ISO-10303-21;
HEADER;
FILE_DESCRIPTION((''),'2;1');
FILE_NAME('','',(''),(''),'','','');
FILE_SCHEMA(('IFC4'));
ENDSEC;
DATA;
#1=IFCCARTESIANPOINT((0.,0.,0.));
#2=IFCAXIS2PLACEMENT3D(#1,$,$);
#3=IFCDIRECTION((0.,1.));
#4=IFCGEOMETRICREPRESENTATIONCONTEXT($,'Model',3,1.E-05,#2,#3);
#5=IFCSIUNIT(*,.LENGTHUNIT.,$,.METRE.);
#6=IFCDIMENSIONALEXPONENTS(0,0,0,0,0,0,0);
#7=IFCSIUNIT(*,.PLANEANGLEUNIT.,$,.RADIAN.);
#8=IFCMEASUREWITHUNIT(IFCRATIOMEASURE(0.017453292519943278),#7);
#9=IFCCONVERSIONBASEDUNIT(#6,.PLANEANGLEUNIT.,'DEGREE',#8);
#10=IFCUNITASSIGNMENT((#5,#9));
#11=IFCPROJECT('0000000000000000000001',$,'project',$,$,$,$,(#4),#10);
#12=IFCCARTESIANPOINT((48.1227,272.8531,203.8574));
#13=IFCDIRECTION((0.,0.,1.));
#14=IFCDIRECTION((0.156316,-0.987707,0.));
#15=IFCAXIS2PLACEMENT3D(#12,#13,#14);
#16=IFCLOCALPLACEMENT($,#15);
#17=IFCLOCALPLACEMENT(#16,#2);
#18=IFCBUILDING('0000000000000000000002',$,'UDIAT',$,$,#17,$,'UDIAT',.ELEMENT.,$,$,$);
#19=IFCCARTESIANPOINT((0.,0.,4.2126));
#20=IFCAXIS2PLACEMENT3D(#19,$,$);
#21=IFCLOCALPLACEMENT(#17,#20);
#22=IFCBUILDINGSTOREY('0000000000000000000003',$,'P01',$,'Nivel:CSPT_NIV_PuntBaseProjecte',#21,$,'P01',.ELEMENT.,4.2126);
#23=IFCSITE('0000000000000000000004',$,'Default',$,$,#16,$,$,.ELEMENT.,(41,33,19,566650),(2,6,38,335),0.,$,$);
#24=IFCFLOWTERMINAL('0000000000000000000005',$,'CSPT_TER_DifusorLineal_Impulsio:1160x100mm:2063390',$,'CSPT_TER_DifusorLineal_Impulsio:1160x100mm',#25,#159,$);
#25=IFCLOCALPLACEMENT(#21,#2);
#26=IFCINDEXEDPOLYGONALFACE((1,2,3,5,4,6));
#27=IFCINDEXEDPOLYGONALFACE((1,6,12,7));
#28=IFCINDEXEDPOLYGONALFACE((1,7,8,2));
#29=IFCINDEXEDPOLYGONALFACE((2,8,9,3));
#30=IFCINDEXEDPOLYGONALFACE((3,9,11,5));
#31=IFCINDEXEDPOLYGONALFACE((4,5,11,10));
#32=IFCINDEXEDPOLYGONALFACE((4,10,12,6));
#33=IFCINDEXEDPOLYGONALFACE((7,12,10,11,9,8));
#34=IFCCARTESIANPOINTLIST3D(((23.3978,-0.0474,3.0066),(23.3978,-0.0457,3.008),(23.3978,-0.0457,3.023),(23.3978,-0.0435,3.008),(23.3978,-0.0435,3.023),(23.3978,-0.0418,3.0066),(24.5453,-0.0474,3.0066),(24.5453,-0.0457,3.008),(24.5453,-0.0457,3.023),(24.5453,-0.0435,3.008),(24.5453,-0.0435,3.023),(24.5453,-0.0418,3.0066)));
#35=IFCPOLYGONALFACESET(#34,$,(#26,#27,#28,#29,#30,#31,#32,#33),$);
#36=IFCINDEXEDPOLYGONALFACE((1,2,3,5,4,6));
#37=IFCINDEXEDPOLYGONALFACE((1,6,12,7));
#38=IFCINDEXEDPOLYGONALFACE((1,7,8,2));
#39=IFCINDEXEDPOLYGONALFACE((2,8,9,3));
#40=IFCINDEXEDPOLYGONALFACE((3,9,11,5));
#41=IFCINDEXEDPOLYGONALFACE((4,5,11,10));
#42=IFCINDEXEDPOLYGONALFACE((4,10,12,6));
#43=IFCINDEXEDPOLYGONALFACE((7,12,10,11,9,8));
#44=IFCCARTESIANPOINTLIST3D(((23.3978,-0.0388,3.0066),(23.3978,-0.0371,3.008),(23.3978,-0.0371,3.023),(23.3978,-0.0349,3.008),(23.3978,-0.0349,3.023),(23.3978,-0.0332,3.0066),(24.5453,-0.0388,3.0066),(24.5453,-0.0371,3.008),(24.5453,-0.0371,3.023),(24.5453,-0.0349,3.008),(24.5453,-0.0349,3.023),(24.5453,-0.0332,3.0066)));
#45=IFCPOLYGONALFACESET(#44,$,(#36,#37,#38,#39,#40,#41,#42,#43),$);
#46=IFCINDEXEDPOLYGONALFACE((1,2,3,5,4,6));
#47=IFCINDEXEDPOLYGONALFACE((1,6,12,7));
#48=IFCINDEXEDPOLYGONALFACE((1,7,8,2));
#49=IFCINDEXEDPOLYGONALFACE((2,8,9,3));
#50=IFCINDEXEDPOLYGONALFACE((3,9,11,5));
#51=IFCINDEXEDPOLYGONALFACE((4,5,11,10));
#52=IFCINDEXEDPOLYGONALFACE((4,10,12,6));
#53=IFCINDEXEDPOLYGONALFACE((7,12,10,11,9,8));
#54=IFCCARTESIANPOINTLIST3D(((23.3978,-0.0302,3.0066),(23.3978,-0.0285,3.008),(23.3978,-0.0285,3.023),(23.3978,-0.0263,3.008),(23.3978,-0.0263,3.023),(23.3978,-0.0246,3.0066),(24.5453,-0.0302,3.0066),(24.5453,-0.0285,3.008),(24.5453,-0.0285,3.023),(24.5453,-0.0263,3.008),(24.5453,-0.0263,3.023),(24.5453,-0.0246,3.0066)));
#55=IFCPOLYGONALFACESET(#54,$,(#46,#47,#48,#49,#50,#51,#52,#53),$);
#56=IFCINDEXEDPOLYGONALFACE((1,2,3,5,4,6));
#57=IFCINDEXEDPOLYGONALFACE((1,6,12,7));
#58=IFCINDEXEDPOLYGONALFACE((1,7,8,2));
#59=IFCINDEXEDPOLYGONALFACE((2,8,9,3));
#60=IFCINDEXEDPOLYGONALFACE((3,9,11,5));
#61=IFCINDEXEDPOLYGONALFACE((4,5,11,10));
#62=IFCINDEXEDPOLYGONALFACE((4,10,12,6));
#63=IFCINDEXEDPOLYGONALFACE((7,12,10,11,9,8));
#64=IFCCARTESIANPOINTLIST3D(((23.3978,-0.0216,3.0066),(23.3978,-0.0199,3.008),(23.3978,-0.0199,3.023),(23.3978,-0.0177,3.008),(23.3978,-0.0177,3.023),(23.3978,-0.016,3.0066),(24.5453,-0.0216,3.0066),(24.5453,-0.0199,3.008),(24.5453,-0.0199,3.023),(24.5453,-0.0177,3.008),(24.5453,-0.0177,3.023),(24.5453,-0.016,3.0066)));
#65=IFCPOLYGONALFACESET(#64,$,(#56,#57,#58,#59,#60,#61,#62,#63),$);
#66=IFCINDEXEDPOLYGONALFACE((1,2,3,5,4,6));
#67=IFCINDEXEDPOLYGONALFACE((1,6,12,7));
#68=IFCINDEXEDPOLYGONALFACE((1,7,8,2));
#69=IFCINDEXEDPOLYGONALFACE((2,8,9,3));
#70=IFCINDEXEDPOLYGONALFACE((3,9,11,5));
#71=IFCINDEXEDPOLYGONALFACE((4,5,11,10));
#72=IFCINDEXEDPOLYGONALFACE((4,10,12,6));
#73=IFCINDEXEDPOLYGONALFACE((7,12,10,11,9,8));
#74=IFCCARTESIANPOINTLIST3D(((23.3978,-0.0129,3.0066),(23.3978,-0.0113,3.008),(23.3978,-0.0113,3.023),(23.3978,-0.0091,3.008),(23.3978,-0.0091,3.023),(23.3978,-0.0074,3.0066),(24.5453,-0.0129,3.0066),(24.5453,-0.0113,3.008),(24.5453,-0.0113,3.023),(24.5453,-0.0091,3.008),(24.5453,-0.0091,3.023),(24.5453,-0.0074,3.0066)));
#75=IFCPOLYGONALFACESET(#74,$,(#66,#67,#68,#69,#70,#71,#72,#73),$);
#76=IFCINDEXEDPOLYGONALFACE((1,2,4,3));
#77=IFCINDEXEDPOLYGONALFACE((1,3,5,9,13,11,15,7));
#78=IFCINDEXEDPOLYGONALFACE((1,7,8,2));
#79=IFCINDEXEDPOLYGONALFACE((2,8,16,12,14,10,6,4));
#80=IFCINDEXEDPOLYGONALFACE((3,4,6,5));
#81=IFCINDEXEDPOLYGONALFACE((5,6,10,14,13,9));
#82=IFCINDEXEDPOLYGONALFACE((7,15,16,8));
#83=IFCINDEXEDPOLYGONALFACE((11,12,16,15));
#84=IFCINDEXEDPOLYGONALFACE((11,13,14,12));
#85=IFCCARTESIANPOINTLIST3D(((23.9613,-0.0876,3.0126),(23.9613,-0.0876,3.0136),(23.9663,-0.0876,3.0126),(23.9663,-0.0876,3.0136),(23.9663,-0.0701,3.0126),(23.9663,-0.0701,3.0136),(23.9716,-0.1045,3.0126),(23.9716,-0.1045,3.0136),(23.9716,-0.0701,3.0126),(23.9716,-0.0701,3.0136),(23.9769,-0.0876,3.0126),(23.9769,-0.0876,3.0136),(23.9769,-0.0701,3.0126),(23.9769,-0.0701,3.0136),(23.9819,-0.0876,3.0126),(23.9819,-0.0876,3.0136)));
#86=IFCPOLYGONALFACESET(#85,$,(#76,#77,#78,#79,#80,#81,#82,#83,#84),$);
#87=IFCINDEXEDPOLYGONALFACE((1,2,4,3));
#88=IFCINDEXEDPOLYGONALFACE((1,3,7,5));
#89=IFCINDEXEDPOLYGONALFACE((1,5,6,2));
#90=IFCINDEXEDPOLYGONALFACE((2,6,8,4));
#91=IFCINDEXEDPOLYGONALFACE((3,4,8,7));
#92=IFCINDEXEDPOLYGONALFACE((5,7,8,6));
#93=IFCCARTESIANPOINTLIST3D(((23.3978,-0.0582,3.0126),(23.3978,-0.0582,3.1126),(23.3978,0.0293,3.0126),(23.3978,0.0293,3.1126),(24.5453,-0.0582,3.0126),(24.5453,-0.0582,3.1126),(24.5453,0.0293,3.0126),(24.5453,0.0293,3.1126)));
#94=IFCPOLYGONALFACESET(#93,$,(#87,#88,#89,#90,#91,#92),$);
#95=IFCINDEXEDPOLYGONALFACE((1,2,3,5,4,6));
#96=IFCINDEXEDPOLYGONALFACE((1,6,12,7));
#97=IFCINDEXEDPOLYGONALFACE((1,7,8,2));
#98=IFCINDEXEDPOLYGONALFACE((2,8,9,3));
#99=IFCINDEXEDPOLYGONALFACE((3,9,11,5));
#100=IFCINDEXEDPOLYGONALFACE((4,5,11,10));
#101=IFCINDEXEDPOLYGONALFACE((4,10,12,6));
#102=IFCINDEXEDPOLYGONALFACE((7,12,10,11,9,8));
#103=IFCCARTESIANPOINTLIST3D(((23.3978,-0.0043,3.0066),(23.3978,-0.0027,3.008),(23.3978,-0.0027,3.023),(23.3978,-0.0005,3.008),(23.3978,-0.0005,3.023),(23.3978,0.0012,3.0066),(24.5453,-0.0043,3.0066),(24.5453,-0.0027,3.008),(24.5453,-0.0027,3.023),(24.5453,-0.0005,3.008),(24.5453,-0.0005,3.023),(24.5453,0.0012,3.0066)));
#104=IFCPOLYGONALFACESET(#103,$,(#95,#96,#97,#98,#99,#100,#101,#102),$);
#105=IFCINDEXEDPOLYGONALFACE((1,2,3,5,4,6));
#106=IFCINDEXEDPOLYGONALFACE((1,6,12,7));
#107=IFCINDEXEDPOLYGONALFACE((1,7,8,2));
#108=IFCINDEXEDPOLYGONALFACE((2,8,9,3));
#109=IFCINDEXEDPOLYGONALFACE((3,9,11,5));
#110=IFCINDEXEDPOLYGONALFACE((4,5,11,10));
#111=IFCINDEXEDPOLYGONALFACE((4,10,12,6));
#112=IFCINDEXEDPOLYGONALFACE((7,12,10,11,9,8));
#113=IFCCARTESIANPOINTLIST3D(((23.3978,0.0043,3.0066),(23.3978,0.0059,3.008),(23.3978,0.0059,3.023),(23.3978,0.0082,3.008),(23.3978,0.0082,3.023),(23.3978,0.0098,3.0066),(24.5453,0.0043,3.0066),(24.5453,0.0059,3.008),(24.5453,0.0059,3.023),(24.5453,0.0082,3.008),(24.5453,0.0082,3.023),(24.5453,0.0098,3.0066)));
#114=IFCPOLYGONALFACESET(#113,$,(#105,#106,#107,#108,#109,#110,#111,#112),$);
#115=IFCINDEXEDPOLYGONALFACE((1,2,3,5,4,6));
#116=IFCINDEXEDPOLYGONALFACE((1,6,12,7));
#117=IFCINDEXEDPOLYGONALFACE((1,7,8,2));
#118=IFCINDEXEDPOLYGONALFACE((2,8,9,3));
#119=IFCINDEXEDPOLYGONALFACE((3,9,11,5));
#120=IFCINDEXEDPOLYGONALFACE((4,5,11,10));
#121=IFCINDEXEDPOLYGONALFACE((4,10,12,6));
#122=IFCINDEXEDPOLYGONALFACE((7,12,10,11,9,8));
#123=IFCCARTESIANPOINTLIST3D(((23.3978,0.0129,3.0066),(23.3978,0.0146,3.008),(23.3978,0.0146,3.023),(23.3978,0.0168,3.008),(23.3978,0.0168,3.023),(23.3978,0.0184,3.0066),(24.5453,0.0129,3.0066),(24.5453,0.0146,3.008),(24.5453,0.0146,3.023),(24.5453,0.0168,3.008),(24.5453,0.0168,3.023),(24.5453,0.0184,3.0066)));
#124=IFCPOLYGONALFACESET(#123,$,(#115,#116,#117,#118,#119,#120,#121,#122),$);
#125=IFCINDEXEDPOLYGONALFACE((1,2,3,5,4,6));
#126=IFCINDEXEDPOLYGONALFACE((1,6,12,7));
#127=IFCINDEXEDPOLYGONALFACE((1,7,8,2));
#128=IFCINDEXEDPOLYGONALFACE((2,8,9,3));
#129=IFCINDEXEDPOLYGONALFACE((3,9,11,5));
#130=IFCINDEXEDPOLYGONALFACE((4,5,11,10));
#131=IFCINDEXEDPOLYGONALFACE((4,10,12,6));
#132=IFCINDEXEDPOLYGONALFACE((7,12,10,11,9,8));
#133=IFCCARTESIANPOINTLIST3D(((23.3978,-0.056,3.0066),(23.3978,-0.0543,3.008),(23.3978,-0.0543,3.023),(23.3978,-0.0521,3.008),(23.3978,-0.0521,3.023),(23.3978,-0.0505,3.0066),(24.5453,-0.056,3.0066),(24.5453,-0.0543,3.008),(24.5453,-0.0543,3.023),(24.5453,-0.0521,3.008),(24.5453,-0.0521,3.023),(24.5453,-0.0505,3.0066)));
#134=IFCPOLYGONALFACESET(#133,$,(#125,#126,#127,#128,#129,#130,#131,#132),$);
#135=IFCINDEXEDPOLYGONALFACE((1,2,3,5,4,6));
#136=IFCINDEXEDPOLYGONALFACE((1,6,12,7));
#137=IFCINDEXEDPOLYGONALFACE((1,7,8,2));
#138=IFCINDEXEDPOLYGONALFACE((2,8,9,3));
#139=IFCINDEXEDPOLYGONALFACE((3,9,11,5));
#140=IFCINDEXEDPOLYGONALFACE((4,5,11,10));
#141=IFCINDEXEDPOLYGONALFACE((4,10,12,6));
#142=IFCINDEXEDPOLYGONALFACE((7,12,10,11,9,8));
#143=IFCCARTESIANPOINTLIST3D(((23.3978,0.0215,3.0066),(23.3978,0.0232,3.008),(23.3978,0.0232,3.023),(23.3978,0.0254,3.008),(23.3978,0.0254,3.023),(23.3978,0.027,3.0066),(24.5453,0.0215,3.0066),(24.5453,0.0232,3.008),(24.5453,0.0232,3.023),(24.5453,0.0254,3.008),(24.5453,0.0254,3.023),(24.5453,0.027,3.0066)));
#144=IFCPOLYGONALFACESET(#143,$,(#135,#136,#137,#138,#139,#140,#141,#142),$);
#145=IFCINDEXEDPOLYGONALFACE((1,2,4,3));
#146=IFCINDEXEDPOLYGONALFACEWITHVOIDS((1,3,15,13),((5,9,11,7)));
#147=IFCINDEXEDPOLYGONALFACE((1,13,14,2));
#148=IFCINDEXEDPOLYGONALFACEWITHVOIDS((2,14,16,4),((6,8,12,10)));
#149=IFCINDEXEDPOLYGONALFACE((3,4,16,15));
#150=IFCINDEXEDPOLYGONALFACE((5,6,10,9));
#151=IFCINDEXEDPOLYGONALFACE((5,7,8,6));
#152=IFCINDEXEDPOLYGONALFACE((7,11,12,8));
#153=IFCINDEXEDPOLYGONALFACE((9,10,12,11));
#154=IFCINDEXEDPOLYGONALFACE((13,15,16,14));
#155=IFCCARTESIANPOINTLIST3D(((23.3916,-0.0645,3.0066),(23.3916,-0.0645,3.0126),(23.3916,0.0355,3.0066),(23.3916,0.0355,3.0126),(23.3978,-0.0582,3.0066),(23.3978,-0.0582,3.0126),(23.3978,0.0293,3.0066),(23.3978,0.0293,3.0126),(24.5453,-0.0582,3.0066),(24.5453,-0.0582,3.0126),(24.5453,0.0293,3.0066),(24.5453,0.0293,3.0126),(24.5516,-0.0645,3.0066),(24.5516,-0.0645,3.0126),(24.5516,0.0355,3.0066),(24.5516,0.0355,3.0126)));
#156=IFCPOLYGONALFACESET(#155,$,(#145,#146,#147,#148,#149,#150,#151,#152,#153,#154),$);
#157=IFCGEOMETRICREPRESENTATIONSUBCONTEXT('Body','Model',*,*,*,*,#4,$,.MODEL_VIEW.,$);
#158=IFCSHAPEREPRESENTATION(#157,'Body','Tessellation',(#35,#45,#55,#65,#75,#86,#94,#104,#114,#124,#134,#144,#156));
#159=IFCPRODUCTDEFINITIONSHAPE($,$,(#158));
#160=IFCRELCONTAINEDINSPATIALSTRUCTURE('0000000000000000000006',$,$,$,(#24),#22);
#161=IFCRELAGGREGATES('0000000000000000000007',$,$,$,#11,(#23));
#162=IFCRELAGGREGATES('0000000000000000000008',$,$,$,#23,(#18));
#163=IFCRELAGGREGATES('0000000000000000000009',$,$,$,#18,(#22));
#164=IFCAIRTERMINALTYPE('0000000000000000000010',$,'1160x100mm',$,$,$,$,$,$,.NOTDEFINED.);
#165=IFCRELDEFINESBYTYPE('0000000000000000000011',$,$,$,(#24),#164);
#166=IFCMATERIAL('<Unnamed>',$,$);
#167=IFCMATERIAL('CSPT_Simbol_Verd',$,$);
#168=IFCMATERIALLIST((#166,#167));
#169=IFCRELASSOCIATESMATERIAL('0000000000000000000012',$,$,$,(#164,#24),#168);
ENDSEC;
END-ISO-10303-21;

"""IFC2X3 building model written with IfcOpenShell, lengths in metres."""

from ifc_helpers import new_model, entity, si_unit, converted_unit, direction, frame, origin, origin_2d_with_axis, place, context, subcontext, project, spatial, polyline, rectangle, outline, extrude, source, transform, mapped, material, material_list, type_object, type_shapes, element, save


model = new_model("IFC2X3")

# Units and contexts
model_context = context("Model", 3, precision=1e-05, world=origin(), true_north=direction((0.0, 1.0)))
body_context = subcontext(model_context, "Body", "Model", "MODEL_VIEW")
ifc_project = project(units=[si_unit("LENGTHUNIT", "METRE"), converted_unit("PLANEANGLEUNIT", "DEGREE", entity("IfcRatioMeasure", 0.017453292519943278), si_unit("PLANEANGLEUNIT", "RADIAN"), dimensions=[0, 0, 0, 0, 0, 0, 0])], contexts=[model_context])

# Site, building, storey
site_placement = place(None, frame((48.1227, 272.8531, 203.8574), z_axis=(0.0, 0.0, 1.0), x_axis=(0.156316, -0.987707, 0.0)))
site = spatial("IfcSite", under=ifc_project, at=site_placement, Name="Default", CompositionType="ELEMENT", RefLatitude=(41, 33, 19, 566650), RefLongitude=(2, 6, 38, 335), RefElevation=0.0)
building_placement = place(site_placement, origin())
building = spatial("IfcBuilding", under=site, at=building_placement, Name="UDIAT", LongName="UDIAT", CompositionType="ELEMENT")
storey_placement = place(building_placement, frame((0.0, 0.0, 4.2126)))
storey = spatial("IfcBuildingStorey", under=building, at=storey_placement, Name="P01", ObjectType="Nivel:CSPT_NIV_PuntBaseProjecte", LongName="P01", CompositionType="ELEMENT", Elevation=4.2126)

# Shared definitions
ifc_material_1 = material(Name="<Unnamed>")

# Flow terminal
ifc_material_2 = material(Name="CSPT_Simbol_Verd")
ifc_material_list = material_list([ifc_material_1, ifc_material_2])
air_terminal_type = type_object("IfcAirTerminalType", Name="1160x100mm", PredefinedType="NOTDEFINED", material=ifc_material_list)
shared_shape_1 = source(origin(), body_context, "Body", "SweptSolid", [
    extrude(outline(polyline([(0.0037, 0.0028), (0.0059, 0.0028), (0.0016, 0.0063), (0.002, 0.0042), (-0.0074, -0.0074), (-0.0057, -0.0088), (0.0037, 0.0028)])), frame((-0.5737, 0.0301, -0.0001), z_axis=(1.0, 0.0, 0.0), x_axis=(0.0, -0.776119, -0.630587)), (0.0, 0.0, 1.0), 1.1475),
    extrude(outline(polyline([(0.0037, 0.0028), (0.0059, 0.0028), (0.0016, 0.0063), (0.002, 0.0042), (-0.0074, -0.0074), (-0.0057, -0.0088), (0.0037, 0.0028)])), frame((-0.5737, 0.0215, -0.0001), z_axis=(1.0, 0.0, 0.0), x_axis=(0.0, -0.776119, -0.630587)), (0.0, 0.0, 1.0), 1.1475),
    extrude(outline(polyline([(0.0037, 0.0028), (0.0059, 0.0028), (0.0016, 0.0063), (0.002, 0.0042), (-0.0074, -0.0074), (-0.0057, -0.0088), (0.0037, 0.0028)])), frame((-0.5737, 0.0129, -0.0001), z_axis=(1.0, 0.0, 0.0), x_axis=(0.0, -0.776119, -0.630587)), (0.0, 0.0, 1.0), 1.1475),
    extrude(outline(polyline([(0.0037, 0.0028), (0.0059, 0.0028), (0.0016, 0.0063), (0.002, 0.0042), (-0.0074, -0.0074), (-0.0057, -0.0088), (0.0037, 0.0028)])), frame((-0.5737, 0.0043, -0.0001), z_axis=(1.0, 0.0, 0.0), x_axis=(0.0, -0.776119, -0.630587)), (0.0, 0.0, 1.0), 1.1475),
    extrude(outline(polyline([(0.0037, 0.0028), (0.0059, 0.0028), (0.0016, 0.0063), (0.002, 0.0042), (-0.0074, -0.0074), (-0.0057, -0.0088), (0.0037, 0.0028)])), frame((-0.5737, -0.0043, -0.0001), z_axis=(1.0, 0.0, 0.0), x_axis=(0.0, -0.776119, -0.630587)), (0.0, 0.0, 1.0), 1.1475),
    extrude(outline(polyline([(0.0, -0.013), (0.0053, -0.013), (0.0053, 0.0045), (0.0103, 0.0045), (0.0, 0.0213), (-0.0103, 0.0045), (-0.0053, 0.0045), (-0.0053, -0.013), (0.0, -0.013)])), frame((0.0, 0.0687, 0.0)), (0.0, 0.0, 1.0), 0.001),
    extrude(rectangle(XDim=1.1475, YDim=0.0875, at=origin_2d_with_axis()), frame((0.0, 0.0, 0.0), z_axis=(0.0, 0.0, 1.0), x_axis=(-1.0, 0.0, 0.0)), (0.0, 0.0, 1.0), 0.1),
    extrude(outline(polyline([(0.0037, 0.0028), (0.0059, 0.0028), (0.0016, 0.0063), (0.002, 0.0042), (-0.0074, -0.0074), (-0.0057, -0.0088), (0.0037, 0.0028)])), frame((-0.5737, -0.0129, -0.0001), z_axis=(1.0, 0.0, 0.0), x_axis=(0.0, -0.776119, -0.630587)), (0.0, 0.0, 1.0), 1.1475),
    extrude(outline(polyline([(0.0037, 0.0028), (0.0059, 0.0028), (0.0016, 0.0063), (0.002, 0.0042), (-0.0074, -0.0074), (-0.0057, -0.0088), (0.0037, 0.0028)])), frame((-0.5737, -0.0215, -0.0001), z_axis=(1.0, 0.0, 0.0), x_axis=(0.0, -0.776119, -0.630587)), (0.0, 0.0, 1.0), 1.1475),
    extrude(outline(polyline([(0.0037, 0.0028), (0.0059, 0.0028), (0.0016, 0.0063), (0.002, 0.0042), (-0.0074, -0.0074), (-0.0057, -0.0088), (0.0037, 0.0028)])), frame((-0.5737, -0.0301, -0.0001), z_axis=(1.0, 0.0, 0.0), x_axis=(0.0, -0.776119, -0.630587)), (0.0, 0.0, 1.0), 1.1475),
    extrude(outline(polyline([(0.0037, 0.0028), (0.0059, 0.0028), (0.0016, 0.0063), (0.002, 0.0042), (-0.0074, -0.0074), (-0.0057, -0.0088), (0.0037, 0.0028)])), frame((-0.5737, 0.0388, -0.0001), z_axis=(1.0, 0.0, 0.0), x_axis=(0.0, -0.776119, -0.630587)), (0.0, 0.0, 1.0), 1.1475),
    extrude(outline(polyline([(0.0037, 0.0028), (0.0059, 0.0028), (0.0016, 0.0063), (0.002, 0.0042), (-0.0074, -0.0074), (-0.0057, -0.0088), (0.0037, 0.0028)])), frame((-0.5737, -0.0387, -0.0001), z_axis=(1.0, 0.0, 0.0), x_axis=(0.0, -0.776119, -0.630587)), (0.0, 0.0, 1.0), 1.1475),
    extrude(outline(polyline([(-0.58, -0.05), (0.58, -0.05), (0.58, 0.05), (-0.58, 0.05), (-0.58, -0.05)]), holes=[polyline([(-0.5738, -0.0438), (-0.5738, 0.0437), (0.5737, 0.0437), (0.5737, -0.0438), (-0.5738, -0.0438)])]), frame((0.0, 0.0, -0.006), z_axis=(0.0, 0.0, 1.0), x_axis=(-1.0, 0.0, 0.0)), (0.0, 0.0, 1.0), 0.006),
])
type_shapes(air_terminal_type, [shared_shape_1])
for number, where, z_axis, x_axis, name in (
    (1, (23.9716, -0.0145, 3.0126), (0.0, 0.0, 1.0), (-1.0, 0.0, 0.0), "CSPT_TER_DifusorLineal_Impulsio:1160x100mm:2063390"),
):
    element("IfcFlowTerminal", number, at=place(storey_placement, frame(where, z_axis=z_axis, x_axis=x_axis)), inside=storey, type_object=air_terminal_type, material=ifc_material_list, Name=name, ObjectType="CSPT_TER_DifusorLineal_Impulsio:1160x100mm", context=body_context, shape_type="MappedRepresentation", body=[
        mapped(shared_shape_1, transform((0.0, 0.0, 0.0), scale=1.0)),
    ])

save(model, "model.ifc")
